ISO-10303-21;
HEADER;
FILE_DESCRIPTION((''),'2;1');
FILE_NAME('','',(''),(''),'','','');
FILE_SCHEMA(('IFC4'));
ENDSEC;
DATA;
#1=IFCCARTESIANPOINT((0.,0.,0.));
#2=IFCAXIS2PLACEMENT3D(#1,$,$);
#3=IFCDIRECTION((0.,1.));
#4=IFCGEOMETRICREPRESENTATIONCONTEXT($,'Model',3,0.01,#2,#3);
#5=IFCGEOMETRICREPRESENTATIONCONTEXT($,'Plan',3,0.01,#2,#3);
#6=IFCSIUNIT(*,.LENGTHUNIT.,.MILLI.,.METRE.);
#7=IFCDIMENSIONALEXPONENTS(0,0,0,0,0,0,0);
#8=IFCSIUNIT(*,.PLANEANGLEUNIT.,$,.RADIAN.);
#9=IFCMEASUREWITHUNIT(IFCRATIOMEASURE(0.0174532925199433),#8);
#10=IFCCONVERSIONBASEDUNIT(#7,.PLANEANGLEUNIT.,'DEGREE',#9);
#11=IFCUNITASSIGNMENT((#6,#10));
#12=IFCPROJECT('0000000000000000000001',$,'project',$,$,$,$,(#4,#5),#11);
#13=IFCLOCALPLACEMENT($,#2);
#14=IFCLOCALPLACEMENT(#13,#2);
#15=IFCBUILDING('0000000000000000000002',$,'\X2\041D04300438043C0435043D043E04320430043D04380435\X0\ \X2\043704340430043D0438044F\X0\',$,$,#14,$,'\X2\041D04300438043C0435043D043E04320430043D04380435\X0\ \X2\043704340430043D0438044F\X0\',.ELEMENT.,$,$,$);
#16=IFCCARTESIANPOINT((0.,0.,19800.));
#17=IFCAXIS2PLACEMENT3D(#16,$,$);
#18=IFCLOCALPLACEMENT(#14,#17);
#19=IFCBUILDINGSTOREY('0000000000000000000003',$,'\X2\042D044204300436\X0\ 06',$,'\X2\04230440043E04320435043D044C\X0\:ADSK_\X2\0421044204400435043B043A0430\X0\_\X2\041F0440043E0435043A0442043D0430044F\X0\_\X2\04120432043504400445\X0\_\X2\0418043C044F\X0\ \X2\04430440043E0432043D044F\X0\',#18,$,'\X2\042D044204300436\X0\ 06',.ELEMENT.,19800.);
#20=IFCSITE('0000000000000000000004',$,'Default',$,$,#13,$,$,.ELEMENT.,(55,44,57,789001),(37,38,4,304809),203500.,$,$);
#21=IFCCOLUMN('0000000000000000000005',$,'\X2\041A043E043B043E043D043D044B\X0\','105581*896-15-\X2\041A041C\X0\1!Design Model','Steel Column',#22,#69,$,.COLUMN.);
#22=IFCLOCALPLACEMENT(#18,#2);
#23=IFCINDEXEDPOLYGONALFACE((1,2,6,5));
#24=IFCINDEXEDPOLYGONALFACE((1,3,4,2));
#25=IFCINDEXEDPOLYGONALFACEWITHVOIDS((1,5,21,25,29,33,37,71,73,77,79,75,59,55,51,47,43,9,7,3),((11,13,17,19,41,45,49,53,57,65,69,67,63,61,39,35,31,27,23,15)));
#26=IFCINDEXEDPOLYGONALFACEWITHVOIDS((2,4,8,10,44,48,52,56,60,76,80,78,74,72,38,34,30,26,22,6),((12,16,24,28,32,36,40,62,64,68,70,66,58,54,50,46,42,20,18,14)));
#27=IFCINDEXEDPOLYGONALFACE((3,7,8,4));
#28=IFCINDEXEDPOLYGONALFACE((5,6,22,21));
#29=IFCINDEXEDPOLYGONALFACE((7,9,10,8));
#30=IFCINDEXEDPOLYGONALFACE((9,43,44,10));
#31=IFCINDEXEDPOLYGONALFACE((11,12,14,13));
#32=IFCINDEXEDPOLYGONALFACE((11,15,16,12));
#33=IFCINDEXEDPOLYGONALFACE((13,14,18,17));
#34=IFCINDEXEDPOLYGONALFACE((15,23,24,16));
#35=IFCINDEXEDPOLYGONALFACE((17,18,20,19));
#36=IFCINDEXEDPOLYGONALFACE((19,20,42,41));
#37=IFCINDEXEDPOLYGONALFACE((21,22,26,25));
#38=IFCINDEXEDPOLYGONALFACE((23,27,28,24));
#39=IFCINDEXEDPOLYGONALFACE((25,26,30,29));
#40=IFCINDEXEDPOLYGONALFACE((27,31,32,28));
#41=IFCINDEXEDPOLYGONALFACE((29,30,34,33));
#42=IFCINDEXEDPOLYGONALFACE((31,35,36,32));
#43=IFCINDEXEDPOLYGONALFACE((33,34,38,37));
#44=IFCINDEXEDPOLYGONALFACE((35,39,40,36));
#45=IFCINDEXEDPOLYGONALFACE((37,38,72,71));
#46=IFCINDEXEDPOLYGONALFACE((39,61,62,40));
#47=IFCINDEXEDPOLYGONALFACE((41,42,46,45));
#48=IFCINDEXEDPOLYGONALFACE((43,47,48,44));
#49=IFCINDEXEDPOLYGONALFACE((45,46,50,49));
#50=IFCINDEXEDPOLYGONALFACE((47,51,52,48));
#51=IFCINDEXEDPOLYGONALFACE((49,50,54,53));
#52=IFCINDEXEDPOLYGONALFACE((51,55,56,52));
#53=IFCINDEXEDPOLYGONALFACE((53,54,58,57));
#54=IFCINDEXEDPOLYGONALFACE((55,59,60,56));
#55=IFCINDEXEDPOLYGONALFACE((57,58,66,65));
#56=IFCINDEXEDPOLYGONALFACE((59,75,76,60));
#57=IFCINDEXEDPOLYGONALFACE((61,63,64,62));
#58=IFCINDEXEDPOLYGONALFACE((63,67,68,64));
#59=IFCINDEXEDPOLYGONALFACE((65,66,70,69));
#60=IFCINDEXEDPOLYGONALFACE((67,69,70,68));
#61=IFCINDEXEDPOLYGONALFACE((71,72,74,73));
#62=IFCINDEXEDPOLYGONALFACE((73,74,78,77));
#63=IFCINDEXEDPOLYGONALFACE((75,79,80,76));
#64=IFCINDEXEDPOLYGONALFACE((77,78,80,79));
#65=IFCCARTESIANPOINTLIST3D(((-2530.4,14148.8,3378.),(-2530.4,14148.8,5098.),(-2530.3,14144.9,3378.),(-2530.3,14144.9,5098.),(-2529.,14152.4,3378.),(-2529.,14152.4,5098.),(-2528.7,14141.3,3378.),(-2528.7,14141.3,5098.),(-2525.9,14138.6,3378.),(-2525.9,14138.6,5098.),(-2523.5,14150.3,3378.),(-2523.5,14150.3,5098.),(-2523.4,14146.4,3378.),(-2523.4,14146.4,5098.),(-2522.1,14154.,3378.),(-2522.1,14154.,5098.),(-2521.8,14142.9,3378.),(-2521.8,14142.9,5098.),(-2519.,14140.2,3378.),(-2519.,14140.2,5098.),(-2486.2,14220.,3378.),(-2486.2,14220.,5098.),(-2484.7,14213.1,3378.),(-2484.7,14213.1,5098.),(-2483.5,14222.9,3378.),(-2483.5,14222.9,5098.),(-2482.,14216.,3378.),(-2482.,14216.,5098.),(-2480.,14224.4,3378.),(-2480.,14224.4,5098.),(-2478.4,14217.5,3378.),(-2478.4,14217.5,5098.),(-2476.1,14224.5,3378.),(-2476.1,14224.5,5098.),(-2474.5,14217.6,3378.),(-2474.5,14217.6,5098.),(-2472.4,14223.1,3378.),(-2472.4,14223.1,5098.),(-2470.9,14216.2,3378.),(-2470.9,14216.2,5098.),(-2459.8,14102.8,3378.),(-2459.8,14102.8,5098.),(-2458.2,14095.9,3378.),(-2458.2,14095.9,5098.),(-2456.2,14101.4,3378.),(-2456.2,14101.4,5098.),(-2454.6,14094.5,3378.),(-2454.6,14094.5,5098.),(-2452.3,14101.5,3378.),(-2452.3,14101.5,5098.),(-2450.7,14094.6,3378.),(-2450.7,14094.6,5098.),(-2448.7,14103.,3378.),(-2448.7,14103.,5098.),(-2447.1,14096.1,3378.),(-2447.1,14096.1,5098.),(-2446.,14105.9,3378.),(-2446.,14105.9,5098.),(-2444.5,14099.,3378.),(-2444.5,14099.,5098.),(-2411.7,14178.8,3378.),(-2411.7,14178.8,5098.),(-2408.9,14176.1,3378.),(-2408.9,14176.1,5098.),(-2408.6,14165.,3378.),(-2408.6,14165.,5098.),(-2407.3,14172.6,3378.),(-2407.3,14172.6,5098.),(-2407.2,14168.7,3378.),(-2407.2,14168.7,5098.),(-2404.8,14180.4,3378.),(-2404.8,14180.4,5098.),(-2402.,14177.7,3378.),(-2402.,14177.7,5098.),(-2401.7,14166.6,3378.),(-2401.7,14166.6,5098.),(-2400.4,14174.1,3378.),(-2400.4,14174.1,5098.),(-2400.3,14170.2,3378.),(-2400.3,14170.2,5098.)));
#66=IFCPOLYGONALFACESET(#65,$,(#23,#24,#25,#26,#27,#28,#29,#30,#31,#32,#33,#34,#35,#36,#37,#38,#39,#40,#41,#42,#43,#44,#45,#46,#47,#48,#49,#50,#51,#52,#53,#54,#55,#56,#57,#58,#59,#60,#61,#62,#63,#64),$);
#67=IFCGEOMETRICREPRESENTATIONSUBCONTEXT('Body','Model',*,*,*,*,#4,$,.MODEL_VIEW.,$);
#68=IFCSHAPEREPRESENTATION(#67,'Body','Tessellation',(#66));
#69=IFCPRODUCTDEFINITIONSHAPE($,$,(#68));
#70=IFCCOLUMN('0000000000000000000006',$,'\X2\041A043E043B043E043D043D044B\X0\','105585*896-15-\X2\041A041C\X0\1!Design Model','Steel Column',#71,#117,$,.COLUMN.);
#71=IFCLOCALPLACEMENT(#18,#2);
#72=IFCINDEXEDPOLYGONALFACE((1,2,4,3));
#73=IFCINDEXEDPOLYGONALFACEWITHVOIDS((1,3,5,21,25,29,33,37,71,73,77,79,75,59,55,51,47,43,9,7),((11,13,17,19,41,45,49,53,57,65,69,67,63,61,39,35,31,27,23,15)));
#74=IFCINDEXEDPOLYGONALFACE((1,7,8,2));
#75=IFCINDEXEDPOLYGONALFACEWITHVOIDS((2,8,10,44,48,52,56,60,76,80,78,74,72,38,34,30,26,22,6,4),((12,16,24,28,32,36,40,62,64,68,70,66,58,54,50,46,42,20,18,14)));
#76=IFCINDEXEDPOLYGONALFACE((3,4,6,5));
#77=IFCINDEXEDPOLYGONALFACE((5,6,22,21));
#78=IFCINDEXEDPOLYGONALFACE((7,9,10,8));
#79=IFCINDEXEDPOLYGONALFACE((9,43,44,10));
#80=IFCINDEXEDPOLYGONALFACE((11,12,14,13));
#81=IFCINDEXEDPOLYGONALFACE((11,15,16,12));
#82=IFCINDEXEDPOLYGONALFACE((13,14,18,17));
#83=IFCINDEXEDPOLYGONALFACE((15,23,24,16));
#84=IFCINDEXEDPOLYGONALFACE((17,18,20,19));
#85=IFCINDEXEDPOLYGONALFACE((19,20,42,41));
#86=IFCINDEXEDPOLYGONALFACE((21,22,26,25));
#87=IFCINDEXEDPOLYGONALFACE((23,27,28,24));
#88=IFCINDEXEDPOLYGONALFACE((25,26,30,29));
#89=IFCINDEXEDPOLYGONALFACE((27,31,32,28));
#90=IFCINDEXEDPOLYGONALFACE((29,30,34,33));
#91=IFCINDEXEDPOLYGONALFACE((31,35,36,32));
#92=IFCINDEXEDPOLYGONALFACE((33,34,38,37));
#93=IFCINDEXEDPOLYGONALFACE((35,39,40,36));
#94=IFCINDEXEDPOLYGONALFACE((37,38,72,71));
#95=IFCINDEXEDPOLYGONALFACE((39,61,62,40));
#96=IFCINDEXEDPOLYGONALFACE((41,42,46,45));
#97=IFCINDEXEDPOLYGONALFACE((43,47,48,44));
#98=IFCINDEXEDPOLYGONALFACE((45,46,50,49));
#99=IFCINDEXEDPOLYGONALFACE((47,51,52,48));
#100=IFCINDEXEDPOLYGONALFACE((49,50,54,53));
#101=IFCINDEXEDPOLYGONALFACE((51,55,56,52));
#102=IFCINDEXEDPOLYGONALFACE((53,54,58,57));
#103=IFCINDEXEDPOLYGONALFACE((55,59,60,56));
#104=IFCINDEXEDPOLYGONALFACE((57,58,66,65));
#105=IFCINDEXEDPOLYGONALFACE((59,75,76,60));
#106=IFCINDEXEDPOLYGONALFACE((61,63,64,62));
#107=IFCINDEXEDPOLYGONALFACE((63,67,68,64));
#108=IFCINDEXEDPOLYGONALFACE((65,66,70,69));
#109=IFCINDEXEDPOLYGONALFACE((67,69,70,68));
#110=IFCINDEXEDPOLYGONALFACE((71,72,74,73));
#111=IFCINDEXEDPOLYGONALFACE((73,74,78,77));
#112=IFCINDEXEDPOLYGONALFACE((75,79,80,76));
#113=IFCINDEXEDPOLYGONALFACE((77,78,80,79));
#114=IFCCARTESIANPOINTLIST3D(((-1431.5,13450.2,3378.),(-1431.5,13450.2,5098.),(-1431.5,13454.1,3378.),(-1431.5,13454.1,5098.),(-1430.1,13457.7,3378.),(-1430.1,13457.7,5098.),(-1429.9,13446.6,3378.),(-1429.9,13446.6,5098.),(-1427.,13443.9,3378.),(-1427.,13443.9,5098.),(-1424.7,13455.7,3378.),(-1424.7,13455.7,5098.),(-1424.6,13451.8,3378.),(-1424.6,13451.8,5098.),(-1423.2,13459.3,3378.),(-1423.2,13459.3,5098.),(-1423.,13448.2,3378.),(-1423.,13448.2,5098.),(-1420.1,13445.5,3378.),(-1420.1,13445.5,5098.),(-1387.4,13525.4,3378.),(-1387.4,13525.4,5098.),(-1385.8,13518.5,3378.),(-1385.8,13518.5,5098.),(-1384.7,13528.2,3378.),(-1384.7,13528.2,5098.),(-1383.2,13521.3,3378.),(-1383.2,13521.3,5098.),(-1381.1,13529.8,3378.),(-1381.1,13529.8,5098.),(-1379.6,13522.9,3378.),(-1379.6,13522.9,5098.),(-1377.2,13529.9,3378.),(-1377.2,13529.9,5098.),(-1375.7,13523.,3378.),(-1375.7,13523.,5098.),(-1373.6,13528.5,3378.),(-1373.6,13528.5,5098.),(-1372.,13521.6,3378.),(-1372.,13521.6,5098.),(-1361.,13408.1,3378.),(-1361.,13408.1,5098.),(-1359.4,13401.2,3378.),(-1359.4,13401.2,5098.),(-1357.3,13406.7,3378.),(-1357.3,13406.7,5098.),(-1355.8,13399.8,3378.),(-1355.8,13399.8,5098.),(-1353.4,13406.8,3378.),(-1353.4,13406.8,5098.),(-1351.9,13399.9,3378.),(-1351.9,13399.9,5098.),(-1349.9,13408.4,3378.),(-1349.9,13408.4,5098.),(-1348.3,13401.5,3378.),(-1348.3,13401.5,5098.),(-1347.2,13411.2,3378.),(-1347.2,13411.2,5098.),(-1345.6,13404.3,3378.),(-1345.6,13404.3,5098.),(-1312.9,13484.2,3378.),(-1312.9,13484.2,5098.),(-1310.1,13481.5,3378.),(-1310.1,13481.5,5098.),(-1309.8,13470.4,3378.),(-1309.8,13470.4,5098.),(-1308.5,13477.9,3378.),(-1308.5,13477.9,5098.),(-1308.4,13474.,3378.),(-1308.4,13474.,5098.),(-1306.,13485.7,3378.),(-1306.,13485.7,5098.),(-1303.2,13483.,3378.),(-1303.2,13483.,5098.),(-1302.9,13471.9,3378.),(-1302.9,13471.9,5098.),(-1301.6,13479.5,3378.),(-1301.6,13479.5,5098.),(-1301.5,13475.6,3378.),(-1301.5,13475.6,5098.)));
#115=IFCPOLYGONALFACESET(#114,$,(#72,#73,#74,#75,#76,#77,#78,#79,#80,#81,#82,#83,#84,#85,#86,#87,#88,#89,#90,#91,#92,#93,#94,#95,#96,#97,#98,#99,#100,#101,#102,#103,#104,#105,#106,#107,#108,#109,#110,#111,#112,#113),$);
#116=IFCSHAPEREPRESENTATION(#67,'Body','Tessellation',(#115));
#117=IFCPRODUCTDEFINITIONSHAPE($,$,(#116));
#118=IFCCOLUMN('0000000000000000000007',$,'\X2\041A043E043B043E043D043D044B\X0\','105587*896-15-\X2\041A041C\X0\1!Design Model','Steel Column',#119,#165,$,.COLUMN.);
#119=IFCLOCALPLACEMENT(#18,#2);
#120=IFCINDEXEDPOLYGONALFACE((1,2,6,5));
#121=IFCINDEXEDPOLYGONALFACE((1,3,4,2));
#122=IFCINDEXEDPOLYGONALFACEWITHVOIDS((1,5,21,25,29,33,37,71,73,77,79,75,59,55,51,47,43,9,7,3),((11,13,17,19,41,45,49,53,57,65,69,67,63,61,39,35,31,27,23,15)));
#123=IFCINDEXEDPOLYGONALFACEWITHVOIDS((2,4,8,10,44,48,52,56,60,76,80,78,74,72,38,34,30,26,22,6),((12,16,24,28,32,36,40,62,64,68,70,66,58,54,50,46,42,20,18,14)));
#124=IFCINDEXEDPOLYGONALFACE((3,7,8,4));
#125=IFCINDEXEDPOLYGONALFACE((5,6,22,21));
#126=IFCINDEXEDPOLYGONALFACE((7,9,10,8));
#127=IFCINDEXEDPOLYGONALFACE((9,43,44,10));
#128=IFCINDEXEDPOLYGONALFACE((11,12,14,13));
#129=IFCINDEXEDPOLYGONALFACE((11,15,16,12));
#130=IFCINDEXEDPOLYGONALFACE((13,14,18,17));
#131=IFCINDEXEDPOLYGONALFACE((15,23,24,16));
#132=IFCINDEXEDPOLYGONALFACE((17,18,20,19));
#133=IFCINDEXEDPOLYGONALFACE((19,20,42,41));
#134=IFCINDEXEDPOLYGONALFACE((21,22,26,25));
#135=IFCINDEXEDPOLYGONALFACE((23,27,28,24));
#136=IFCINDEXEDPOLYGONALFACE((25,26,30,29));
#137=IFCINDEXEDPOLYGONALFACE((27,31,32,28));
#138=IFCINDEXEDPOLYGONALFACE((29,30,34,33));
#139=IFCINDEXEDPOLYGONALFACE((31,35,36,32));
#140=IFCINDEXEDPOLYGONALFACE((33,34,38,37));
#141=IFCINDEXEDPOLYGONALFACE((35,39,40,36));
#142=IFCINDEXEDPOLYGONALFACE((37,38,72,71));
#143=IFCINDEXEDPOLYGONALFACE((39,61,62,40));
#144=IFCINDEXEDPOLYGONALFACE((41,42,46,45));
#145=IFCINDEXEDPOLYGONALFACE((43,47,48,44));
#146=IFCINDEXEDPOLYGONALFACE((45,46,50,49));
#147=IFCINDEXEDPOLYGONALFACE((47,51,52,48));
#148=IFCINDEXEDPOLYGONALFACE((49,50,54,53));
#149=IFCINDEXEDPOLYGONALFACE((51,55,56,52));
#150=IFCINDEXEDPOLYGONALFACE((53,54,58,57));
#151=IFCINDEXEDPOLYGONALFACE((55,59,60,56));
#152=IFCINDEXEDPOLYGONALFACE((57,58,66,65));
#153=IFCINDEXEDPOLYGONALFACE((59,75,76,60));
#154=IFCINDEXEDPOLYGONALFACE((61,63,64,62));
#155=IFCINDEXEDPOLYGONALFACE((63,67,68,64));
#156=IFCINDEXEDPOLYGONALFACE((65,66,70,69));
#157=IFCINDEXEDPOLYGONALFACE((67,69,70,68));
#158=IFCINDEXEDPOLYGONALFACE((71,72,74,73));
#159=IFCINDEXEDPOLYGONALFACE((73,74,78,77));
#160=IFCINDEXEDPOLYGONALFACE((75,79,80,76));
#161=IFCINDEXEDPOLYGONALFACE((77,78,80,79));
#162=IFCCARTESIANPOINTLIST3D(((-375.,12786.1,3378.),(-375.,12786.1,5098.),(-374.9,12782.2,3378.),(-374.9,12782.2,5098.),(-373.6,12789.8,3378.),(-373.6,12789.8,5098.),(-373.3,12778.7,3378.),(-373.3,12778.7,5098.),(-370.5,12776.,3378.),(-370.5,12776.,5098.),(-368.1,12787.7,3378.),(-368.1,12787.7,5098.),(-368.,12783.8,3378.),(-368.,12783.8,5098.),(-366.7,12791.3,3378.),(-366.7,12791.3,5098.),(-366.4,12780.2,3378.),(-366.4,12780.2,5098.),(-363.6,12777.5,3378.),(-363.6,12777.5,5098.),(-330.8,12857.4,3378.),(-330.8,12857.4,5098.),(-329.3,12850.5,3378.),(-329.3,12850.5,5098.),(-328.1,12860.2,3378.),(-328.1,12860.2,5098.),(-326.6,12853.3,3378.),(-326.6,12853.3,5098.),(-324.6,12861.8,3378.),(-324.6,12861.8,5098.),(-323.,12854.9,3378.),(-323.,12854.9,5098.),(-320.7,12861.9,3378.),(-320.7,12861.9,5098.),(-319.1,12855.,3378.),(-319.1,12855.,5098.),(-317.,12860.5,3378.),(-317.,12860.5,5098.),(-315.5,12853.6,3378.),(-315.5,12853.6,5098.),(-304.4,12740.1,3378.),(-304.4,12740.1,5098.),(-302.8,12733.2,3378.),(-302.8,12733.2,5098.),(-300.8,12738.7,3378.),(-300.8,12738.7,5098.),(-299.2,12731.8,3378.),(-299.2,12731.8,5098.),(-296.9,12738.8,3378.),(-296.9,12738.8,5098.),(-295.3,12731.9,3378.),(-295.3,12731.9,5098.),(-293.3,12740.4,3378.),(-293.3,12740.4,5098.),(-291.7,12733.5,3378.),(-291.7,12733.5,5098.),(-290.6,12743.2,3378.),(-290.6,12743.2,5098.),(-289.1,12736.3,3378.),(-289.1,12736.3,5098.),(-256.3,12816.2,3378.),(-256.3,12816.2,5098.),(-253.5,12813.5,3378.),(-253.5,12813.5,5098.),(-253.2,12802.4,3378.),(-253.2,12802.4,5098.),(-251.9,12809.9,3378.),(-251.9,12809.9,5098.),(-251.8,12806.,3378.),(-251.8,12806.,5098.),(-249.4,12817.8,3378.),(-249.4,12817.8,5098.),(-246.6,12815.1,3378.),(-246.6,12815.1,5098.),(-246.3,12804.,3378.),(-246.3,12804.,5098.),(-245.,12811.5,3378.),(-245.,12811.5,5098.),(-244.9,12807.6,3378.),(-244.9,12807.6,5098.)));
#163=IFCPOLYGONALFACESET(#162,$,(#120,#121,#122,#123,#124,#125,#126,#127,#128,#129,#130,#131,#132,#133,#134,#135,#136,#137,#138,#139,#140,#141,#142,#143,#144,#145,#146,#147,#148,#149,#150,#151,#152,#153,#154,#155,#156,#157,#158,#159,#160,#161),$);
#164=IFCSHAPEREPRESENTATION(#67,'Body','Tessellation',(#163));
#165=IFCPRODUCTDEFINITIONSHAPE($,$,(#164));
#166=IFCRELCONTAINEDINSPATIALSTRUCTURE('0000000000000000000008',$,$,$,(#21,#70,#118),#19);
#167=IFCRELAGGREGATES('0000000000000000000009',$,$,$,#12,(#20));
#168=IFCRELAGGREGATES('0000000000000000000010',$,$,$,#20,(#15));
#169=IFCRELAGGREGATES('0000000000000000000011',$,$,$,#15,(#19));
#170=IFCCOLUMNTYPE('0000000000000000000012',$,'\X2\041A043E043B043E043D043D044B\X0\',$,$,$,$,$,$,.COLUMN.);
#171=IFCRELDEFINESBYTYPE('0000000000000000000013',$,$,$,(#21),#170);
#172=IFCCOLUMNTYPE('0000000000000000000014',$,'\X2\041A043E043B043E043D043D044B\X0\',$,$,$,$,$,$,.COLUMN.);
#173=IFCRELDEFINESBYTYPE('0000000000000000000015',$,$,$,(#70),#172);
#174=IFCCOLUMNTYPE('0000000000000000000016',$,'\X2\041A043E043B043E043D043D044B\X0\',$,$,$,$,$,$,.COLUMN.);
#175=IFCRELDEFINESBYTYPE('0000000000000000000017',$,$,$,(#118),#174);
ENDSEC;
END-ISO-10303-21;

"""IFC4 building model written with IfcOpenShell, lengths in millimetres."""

from ifc_helpers import new_model, entity, si_unit, converted_unit, direction, frame, origin, place, context, subcontext, project, spatial, indexed_curve, outline, extrude, type_object, element, save


model = new_model("IFC4")

# Units and contexts
model_context = context("Model", 3, precision=0.01, world=origin(), true_north=direction((0.0, 1.0)))
plan_context = context("Plan", 3, precision=0.01, world=origin(), true_north=direction((0.0, 1.0)))
body_context = subcontext(model_context, "Body", "Model", "MODEL_VIEW")
ifc_project = project(units=[si_unit("LENGTHUNIT", "METRE", prefix="MILLI"), converted_unit("PLANEANGLEUNIT", "DEGREE", entity("IfcRatioMeasure", 0.0174532925199433), si_unit("PLANEANGLEUNIT", "RADIAN"), dimensions=[0, 0, 0, 0, 0, 0, 0])], contexts=[model_context, plan_context])

# Site, building, storey
site_placement = place(None, origin())
site = spatial("IfcSite", under=ifc_project, at=site_placement, Name="Default", CompositionType="ELEMENT", RefLatitude=(55, 44, 57, 789001), RefLongitude=(37, 38, 4, 304809), RefElevation=203500.0)
building_placement = place(site_placement, origin())
building = spatial("IfcBuilding", under=site, at=building_placement, Name="Наименование здания", LongName="Наименование здания", CompositionType="ELEMENT")
storey_placement = place(building_placement, frame((0.0, 0.0, 19800.0)))
storey = spatial("IfcBuildingStorey", under=building, at=storey_placement, Name="Этаж 06", ObjectType="Уровень:ADSK_Стрелка_Проектная_Вверх_Имя уровня", LongName="Этаж 06", CompositionType="ELEMENT", Elevation=19800.0)

# Columns
placement_1 = place(storey_placement, origin())
column_type_1 = type_object("IfcColumnType", Name="Колонны", PredefinedType="COLUMN")
element("IfcColumn", 1, at=placement_1, inside=storey, type_object=column_type_1, Name="Колонны", Description="105581*896-15-КМ1!Design Model", ObjectType="Steel Column", PredefinedType="COLUMN", context=body_context, shape_type="SweptSolid", body=[
    extrude(outline(indexed_curve([(29.5, -56.8), (33.4, -56.8), (37.0, -55.3), (39.7, -52.6), (41.2, -49.0), (56.8, 29.5), (56.8, 33.4), (55.3, 37.0), (52.6, 39.7), (49.0, 41.2), (-29.5, 56.8), (-33.4, 56.8), (-37.0, 55.3), (-39.7, 52.6), (-41.2, 49.0), (-56.8, -29.5), (-56.8, -33.4), (-55.3, -37.0), (-52.6, -39.7), (-49.0, -41.2), (29.5, -56.8)], self_intersect=False), holes=[indexed_curve([(-43.1, -37.3), (-46.7, -35.8), (-49.5, -33.1), (-51.0, -29.5), (-51.0, -25.5), (-37.3, 43.1), (-35.8, 46.7), (-33.1, 49.5), (-29.5, 51.0), (-25.5, 51.0), (43.1, 37.3), (46.7, 35.8), (49.5, 33.1), (51.0, 29.5), (51.0, 25.5), (37.3, -43.1), (35.8, -46.7), (33.1, -49.5), (29.5, -51.0), (25.5, -51.0), (-43.1, -37.3)], self_intersect=False)]), frame((-2465.3, 14159.5, 3378.0), z_axis=(0.0, 0.0, 1.0), x_axis=(-0.933263, 0.359194, 0.0)), (0.0, 0.0, 1.0), 1720.0),
])
column_type_2 = type_object("IfcColumnType", Name="Колонны", PredefinedType="COLUMN")
element("IfcColumn", 2, at=placement_1, inside=storey, type_object=column_type_2, Name="Колонны", Description="105585*896-15-КМ1!Design Model", ObjectType="Steel Column", PredefinedType="COLUMN", context=body_context, shape_type="SweptSolid", body=[
    extrude(outline(indexed_curve([(29.5, -56.8), (33.4, -56.8), (37.0, -55.3), (39.7, -52.6), (41.2, -49.0), (56.8, 29.5), (56.8, 33.4), (55.3, 37.0), (52.6, 39.7), (49.0, 41.2), (-29.5, 56.8), (-33.4, 56.8), (-37.0, 55.3), (-39.7, 52.6), (-41.2, 49.0), (-56.8, -29.5), (-56.8, -33.4), (-55.3, -37.0), (-52.6, -39.7), (-49.0, -41.2), (29.5, -56.8)], self_intersect=False), holes=[indexed_curve([(-43.1, -37.3), (-46.7, -35.8), (-49.5, -33.1), (-51.0, -29.5), (-51.0, -25.5), (-37.3, 43.1), (-35.8, 46.7), (-33.1, 49.5), (-29.5, 51.0), (-25.5, 51.0), (43.1, 37.3), (46.7, 35.8), (49.5, 33.1), (51.0, 29.5), (51.0, 25.5), (37.3, -43.1), (35.8, -46.7), (33.1, -49.5), (29.5, -51.0), (25.5, -51.0), (-43.1, -37.3)], self_intersect=False)]), frame((-1366.5, 13464.8, 3378.0), z_axis=(0.0, 0.0, 1.0), x_axis=(-0.933263, 0.359194, 0.0)), (0.0, 0.0, 1.0), 1720.0),
])
column_type_3 = type_object("IfcColumnType", Name="Колонны", PredefinedType="COLUMN")
element("IfcColumn", 3, at=placement_1, inside=storey, type_object=column_type_3, Name="Колонны", Description="105587*896-15-КМ1!Design Model", ObjectType="Steel Column", PredefinedType="COLUMN", context=body_context, shape_type="SweptSolid", body=[
    extrude(outline(indexed_curve([(29.5, -56.8), (33.4, -56.8), (37.0, -55.3), (39.7, -52.6), (41.2, -49.0), (56.8, 29.5), (56.8, 33.4), (55.3, 37.0), (52.6, 39.7), (49.0, 41.2), (-29.5, 56.8), (-33.4, 56.8), (-37.0, 55.3), (-39.7, 52.6), (-41.2, 49.0), (-56.8, -29.5), (-56.8, -33.4), (-55.3, -37.0), (-52.6, -39.7), (-49.0, -41.2), (29.5, -56.8)], self_intersect=False), holes=[indexed_curve([(-43.1, -37.3), (-46.7, -35.8), (-49.5, -33.1), (-51.0, -29.5), (-51.0, -25.5), (-37.3, 43.1), (-35.8, 46.7), (-33.1, 49.5), (-29.5, 51.0), (-25.5, 51.0), (43.1, 37.3), (46.7, 35.8), (49.5, 33.1), (51.0, 29.5), (51.0, 25.5), (37.3, -43.1), (35.8, -46.7), (33.1, -49.5), (29.5, -51.0), (25.5, -51.0), (-43.1, -37.3)], self_intersect=False)]), frame((-309.9, 12796.9, 3378.0), z_axis=(0.0, 0.0, 1.0), x_axis=(-0.933263, 0.359194, 0.0)), (0.0, 0.0, 1.0), 1720.0),
])

save(model, "model.ifc")
